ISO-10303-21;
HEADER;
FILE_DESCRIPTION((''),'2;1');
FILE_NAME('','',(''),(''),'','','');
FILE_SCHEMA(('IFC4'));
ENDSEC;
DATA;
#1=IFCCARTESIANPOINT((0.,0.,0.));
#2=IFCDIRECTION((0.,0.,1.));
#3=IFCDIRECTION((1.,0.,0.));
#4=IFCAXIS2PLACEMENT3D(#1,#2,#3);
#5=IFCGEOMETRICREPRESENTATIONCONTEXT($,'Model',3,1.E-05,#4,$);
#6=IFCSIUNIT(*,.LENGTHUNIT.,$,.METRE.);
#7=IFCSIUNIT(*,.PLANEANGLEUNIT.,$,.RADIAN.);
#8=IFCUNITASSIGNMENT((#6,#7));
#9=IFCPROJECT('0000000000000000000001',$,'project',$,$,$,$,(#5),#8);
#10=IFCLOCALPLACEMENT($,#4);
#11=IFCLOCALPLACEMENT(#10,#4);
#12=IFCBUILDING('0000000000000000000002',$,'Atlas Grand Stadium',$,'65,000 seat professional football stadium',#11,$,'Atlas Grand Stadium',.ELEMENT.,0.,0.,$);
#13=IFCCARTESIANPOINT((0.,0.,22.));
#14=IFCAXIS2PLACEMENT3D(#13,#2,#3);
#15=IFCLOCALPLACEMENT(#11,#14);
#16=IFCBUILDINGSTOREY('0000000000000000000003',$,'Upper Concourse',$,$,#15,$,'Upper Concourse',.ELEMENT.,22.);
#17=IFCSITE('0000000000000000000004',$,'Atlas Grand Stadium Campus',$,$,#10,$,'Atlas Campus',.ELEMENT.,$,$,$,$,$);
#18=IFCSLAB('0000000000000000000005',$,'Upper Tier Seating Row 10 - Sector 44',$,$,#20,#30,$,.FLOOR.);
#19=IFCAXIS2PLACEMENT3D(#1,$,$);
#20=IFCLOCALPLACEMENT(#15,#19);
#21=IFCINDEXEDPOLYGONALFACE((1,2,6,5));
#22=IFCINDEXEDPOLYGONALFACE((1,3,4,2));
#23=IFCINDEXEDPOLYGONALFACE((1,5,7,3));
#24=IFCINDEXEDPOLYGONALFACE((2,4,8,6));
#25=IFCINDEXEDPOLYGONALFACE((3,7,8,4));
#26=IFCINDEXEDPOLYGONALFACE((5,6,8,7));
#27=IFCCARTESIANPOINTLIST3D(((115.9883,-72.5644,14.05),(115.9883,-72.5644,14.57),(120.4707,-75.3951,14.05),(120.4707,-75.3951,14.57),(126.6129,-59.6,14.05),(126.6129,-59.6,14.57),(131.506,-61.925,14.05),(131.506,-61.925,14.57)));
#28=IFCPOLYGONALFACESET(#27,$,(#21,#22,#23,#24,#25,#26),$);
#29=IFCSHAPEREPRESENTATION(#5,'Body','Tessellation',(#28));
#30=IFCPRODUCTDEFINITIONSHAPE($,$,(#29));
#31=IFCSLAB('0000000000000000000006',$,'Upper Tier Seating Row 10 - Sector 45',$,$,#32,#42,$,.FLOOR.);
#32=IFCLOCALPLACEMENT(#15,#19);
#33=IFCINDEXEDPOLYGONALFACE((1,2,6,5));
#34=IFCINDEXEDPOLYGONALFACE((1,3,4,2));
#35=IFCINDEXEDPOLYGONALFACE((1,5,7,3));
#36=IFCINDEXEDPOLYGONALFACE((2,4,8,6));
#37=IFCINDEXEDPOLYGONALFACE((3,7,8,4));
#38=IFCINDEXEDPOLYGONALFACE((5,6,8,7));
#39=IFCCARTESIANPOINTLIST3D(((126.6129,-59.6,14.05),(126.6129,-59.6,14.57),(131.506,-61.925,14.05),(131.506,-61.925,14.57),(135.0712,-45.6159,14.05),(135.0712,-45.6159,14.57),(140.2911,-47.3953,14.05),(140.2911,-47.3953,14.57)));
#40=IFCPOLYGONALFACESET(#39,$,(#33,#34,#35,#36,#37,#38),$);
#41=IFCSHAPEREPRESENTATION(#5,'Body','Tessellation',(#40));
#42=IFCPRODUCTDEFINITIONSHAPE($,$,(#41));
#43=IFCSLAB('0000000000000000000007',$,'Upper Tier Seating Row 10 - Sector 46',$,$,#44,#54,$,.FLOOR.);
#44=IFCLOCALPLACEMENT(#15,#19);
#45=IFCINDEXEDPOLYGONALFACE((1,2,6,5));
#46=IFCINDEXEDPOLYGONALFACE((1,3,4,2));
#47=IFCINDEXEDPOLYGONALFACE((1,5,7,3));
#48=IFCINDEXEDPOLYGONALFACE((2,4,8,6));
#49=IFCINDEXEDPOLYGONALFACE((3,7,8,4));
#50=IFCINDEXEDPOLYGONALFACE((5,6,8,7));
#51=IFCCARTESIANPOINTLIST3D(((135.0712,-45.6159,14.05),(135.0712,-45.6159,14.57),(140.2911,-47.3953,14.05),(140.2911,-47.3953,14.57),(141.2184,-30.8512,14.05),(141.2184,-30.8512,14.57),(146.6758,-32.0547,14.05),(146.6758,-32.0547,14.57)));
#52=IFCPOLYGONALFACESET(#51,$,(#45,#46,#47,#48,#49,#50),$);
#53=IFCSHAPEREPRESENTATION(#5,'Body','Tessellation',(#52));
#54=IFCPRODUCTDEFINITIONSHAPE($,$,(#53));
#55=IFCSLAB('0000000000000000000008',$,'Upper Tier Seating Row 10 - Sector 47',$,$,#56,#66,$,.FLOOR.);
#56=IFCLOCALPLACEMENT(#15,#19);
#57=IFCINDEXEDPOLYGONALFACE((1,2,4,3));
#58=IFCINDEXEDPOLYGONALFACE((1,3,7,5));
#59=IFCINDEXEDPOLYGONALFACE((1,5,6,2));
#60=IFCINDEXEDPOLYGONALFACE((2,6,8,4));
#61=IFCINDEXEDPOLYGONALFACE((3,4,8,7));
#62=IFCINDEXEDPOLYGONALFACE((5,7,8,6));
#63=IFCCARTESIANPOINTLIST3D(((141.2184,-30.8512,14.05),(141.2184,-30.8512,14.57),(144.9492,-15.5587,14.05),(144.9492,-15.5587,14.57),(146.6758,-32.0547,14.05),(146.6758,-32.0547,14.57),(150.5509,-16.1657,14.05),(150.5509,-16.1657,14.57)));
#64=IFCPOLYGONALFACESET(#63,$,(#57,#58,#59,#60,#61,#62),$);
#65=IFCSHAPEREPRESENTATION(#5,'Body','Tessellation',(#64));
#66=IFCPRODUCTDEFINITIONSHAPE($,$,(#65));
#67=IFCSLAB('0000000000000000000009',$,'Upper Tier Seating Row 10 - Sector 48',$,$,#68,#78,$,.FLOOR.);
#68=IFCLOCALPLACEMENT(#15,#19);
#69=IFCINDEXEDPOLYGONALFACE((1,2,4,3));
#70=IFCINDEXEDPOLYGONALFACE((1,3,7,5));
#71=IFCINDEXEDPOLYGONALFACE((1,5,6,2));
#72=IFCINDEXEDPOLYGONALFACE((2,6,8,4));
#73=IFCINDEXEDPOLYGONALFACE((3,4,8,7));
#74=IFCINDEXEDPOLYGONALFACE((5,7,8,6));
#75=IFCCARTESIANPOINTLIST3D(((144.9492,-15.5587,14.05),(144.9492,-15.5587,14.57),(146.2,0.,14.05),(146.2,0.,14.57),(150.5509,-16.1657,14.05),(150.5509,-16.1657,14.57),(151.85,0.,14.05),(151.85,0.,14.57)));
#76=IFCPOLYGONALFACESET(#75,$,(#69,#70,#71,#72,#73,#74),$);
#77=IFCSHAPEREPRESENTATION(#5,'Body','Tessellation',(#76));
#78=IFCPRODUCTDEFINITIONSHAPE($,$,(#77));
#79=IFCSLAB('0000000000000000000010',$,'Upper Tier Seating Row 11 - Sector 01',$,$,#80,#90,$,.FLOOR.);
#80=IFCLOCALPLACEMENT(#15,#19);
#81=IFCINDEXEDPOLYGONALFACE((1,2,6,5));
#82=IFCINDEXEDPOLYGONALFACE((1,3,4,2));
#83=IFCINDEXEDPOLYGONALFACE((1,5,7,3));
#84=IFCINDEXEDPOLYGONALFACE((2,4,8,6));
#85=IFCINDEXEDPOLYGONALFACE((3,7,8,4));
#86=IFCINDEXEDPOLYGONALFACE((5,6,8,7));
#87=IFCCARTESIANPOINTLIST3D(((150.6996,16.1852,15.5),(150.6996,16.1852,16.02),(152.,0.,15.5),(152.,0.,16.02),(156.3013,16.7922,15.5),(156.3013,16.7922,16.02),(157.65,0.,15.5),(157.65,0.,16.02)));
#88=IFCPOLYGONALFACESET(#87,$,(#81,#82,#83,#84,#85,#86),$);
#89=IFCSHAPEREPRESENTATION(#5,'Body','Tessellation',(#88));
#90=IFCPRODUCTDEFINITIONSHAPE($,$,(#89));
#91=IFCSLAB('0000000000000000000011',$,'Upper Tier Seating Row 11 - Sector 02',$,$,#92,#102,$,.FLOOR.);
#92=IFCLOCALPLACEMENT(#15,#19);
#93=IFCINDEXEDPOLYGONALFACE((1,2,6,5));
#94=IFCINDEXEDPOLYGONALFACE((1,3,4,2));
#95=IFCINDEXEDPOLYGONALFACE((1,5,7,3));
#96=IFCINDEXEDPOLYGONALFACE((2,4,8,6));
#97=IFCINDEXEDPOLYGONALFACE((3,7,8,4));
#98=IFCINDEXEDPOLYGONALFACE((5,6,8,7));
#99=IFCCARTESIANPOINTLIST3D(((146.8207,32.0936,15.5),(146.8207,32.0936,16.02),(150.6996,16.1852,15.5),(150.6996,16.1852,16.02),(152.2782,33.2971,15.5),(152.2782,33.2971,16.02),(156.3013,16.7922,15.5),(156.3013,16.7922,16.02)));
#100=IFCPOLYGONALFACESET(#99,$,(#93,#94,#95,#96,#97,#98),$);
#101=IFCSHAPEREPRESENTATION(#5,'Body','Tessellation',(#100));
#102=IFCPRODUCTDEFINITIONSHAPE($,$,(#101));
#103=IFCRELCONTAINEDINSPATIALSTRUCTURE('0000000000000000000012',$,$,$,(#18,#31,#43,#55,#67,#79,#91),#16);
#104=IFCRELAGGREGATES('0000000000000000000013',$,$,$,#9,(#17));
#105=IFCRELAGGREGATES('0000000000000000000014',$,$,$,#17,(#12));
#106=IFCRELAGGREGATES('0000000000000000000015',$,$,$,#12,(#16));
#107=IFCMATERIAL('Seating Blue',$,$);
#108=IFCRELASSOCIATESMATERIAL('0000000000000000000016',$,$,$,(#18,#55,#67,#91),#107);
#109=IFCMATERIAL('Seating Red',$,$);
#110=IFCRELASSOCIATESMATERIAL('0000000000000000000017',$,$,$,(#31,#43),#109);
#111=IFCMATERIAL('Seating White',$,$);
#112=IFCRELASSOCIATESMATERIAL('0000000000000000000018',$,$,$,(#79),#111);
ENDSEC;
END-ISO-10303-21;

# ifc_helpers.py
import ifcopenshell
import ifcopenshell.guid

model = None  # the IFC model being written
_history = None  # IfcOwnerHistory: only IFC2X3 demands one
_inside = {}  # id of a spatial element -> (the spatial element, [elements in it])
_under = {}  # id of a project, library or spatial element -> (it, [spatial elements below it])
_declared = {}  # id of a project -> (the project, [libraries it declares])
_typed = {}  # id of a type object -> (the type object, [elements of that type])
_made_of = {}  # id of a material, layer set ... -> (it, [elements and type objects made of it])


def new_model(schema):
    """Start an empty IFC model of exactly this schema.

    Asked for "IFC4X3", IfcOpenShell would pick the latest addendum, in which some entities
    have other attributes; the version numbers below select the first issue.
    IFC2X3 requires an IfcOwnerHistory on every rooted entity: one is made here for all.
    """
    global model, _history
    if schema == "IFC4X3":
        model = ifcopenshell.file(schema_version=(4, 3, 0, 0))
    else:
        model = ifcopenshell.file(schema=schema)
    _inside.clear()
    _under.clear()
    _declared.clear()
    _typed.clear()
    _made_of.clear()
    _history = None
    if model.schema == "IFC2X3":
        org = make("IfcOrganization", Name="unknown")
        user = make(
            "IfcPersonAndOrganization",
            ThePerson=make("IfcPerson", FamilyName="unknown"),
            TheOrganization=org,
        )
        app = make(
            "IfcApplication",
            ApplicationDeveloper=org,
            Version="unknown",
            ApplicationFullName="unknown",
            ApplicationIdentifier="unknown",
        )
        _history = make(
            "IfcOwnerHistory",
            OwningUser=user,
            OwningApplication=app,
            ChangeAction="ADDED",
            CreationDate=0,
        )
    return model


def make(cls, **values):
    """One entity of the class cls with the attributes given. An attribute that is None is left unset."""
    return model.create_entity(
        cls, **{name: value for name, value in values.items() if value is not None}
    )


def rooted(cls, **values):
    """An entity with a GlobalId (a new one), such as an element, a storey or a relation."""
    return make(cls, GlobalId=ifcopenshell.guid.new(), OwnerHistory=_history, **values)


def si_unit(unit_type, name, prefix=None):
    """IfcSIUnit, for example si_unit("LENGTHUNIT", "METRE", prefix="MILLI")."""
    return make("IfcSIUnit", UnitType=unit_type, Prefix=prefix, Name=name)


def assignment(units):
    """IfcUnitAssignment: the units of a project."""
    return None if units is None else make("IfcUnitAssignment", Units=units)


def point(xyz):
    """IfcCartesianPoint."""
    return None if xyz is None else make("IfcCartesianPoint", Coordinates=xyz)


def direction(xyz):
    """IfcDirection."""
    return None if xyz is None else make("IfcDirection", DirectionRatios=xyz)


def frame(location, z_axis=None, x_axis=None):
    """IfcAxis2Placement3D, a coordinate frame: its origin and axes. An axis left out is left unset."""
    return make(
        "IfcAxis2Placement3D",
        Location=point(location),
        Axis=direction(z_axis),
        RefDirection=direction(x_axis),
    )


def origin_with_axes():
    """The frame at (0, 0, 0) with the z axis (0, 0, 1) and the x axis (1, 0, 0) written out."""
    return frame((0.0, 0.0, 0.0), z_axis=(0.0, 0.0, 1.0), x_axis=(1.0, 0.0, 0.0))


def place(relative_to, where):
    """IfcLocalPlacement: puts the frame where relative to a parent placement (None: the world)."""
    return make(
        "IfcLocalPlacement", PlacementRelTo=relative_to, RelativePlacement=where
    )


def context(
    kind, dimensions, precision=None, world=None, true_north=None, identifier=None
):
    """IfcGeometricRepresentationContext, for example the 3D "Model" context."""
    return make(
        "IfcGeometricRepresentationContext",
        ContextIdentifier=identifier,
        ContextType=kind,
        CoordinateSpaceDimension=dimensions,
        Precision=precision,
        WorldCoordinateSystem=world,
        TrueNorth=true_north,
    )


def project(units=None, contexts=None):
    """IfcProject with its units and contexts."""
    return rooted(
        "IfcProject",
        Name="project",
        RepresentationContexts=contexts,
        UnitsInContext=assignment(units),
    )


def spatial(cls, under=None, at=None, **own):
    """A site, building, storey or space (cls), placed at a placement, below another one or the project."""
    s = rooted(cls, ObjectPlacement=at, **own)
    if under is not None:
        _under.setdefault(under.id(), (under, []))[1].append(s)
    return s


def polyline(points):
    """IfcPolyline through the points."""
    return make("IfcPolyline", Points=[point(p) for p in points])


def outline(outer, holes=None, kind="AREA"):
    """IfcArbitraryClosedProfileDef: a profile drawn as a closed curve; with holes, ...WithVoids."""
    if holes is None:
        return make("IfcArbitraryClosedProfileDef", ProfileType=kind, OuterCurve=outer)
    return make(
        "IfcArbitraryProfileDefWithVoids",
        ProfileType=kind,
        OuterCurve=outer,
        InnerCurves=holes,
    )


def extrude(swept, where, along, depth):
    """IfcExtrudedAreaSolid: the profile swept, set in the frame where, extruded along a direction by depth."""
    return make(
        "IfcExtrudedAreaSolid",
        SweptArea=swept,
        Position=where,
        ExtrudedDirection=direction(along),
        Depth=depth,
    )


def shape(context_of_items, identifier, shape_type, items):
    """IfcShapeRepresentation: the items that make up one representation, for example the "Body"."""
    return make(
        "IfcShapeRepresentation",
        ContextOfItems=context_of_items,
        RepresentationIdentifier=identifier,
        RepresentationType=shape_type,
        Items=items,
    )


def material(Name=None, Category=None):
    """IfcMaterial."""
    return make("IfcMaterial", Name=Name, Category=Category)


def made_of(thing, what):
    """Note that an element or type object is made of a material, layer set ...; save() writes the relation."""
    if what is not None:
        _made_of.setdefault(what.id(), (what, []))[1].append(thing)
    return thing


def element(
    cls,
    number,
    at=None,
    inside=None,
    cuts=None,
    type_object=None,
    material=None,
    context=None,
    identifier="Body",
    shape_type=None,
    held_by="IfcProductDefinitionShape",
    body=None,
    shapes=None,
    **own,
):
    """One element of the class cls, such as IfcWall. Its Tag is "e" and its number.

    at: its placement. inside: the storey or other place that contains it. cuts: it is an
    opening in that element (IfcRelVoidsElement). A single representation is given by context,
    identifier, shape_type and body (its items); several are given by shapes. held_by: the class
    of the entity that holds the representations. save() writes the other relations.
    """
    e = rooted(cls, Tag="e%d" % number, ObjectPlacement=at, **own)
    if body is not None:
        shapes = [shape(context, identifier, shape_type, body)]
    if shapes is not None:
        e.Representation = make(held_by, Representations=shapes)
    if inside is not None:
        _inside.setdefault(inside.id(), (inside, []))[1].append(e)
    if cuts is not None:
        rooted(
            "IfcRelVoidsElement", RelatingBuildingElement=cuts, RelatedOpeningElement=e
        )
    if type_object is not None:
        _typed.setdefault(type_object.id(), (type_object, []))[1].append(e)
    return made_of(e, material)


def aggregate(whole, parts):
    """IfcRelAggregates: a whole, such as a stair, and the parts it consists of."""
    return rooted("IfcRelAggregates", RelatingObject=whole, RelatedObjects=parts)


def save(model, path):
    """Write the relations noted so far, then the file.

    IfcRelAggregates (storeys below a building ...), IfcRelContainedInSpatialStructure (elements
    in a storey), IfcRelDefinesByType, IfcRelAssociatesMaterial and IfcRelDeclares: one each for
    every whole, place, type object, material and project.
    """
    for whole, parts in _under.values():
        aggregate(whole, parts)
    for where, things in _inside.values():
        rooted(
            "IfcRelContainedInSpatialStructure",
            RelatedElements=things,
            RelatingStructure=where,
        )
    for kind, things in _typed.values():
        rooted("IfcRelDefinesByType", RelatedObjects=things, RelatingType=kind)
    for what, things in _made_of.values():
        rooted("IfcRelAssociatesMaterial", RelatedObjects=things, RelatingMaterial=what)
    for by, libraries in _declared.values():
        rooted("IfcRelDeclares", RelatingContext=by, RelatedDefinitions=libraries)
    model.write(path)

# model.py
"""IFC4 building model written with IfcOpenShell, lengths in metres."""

from ifc_helpers import new_model, si_unit, frame, origin_with_axes, place, context, project, spatial, polyline, outline, extrude, material, element, save


model = new_model("IFC4")

# Units and contexts
model_context = context("Model", 3, precision=1e-05, world=origin_with_axes())
ifc_project = project(units=[si_unit("LENGTHUNIT", "METRE"), si_unit("PLANEANGLEUNIT", "RADIAN")], contexts=[model_context])

# Site, building, storey
site_placement = place(None, origin_with_axes())
site = spatial("IfcSite", under=ifc_project, at=site_placement, Name="Atlas Grand Stadium Campus", LongName="Atlas Campus", CompositionType="ELEMENT")
building_placement = place(site_placement, origin_with_axes())
building = spatial("IfcBuilding", under=site, at=building_placement, Name="Atlas Grand Stadium", ObjectType="65,000 seat professional football stadium", LongName="Atlas Grand Stadium", CompositionType="ELEMENT", ElevationOfRefHeight=0.0, ElevationOfTerrain=0.0)
storey_placement = place(building_placement, frame((0.0, 0.0, 22.0), z_axis=(0.0, 0.0, 1.0), x_axis=(1.0, 0.0, 0.0)))
storey = spatial("IfcBuildingStorey", under=building, at=storey_placement, Name="Upper Concourse", LongName="Upper Concourse", CompositionType="ELEMENT", Elevation=22.0)

# Slabs
ifc_material_1 = material(Name="Seating Blue")
ifc_material_2 = material(Name="Seating Red")
ifc_material_3 = material(Name="Seating White")
slab_1_placement = place(storey_placement, frame((0.0, 0.0, 14.05), z_axis=(0.0, 0.0, 1.0), x_axis=(1.0, 0.0, 0.0)))
element("IfcSlab", 1, at=slab_1_placement, inside=storey, material=ifc_material_1, Name="Upper Tier Seating Row 10 - Sector 44", PredefinedType="FLOOR", context=model_context, shape_type="SweptSolid", body=[
    extrude(outline(polyline([(120.4707, -75.3951), (131.506, -61.925), (126.6129, -59.6), (115.9883, -72.5644), (120.4707, -75.3951)])), origin_with_axes(), (0.0, 0.0, 1.0), 0.52),
])
slab_2_placement = place(storey_placement, frame((0.0, 0.0, 14.05), z_axis=(0.0, 0.0, 1.0), x_axis=(1.0, 0.0, 0.0)))
element("IfcSlab", 2, at=slab_2_placement, inside=storey, material=ifc_material_2, Name="Upper Tier Seating Row 10 - Sector 45", PredefinedType="FLOOR", context=model_context, shape_type="SweptSolid", body=[
    extrude(outline(polyline([(131.506, -61.925), (140.2911, -47.3953), (135.0712, -45.6159), (126.6129, -59.6), (131.506, -61.925)])), origin_with_axes(), (0.0, 0.0, 1.0), 0.52),
])
slab_3_placement = place(storey_placement, frame((0.0, 0.0, 14.05), z_axis=(0.0, 0.0, 1.0), x_axis=(1.0, 0.0, 0.0)))
element("IfcSlab", 3, at=slab_3_placement, inside=storey, material=ifc_material_2, Name="Upper Tier Seating Row 10 - Sector 46", PredefinedType="FLOOR", context=model_context, shape_type="SweptSolid", body=[
    extrude(outline(polyline([(140.2911, -47.3953), (146.6758, -32.0547), (141.2184, -30.8512), (135.0712, -45.6159), (140.2911, -47.3953)])), origin_with_axes(), (0.0, 0.0, 1.0), 0.52),
])
slab_4_placement = place(storey_placement, frame((0.0, 0.0, 14.05), z_axis=(0.0, 0.0, 1.0), x_axis=(1.0, 0.0, 0.0)))
element("IfcSlab", 4, at=slab_4_placement, inside=storey, material=ifc_material_1, Name="Upper Tier Seating Row 10 - Sector 47", PredefinedType="FLOOR", context=model_context, shape_type="SweptSolid", body=[
    extrude(outline(polyline([(146.6758, -32.0547), (150.5509, -16.1657), (144.9492, -15.5587), (141.2184, -30.8512), (146.6758, -32.0547)])), origin_with_axes(), (0.0, 0.0, 1.0), 0.52),
])
slab_5_placement = place(storey_placement, frame((0.0, 0.0, 14.05), z_axis=(0.0, 0.0, 1.0), x_axis=(1.0, 0.0, 0.0)))
element("IfcSlab", 5, at=slab_5_placement, inside=storey, material=ifc_material_1, Name="Upper Tier Seating Row 10 - Sector 48", PredefinedType="FLOOR", context=model_context, shape_type="SweptSolid", body=[
    extrude(outline(polyline([(150.5509, -16.1657), (151.85, 0.0), (146.2, 0.0), (144.9492, -15.5587), (150.5509, -16.1657)])), origin_with_axes(), (0.0, 0.0, 1.0), 0.52),
])
slab_6_placement = place(storey_placement, frame((0.0, 0.0, 15.5), z_axis=(0.0, 0.0, 1.0), x_axis=(1.0, 0.0, 0.0)))
element("IfcSlab", 6, at=slab_6_placement, inside=storey, material=ifc_material_3, Name="Upper Tier Seating Row 11 - Sector 01", PredefinedType="FLOOR", context=model_context, shape_type="SweptSolid", body=[
    extrude(outline(polyline([(157.65, 0.0), (156.3013, 16.7922), (150.6996, 16.1852), (152.0, 0.0), (157.65, 0.0)])), origin_with_axes(), (0.0, 0.0, 1.0), 0.52),
])
slab_7_placement = place(storey_placement, frame((0.0, 0.0, 15.5), z_axis=(0.0, 0.0, 1.0), x_axis=(1.0, 0.0, 0.0)))
element("IfcSlab", 7, at=slab_7_placement, inside=storey, material=ifc_material_1, Name="Upper Tier Seating Row 11 - Sector 02", PredefinedType="FLOOR", context=model_context, shape_type="SweptSolid", body=[
    extrude(outline(polyline([(156.3013, 16.7922), (152.2782, 33.2971), (146.8207, 32.0936), (150.6996, 16.1852), (156.3013, 16.7922)])), origin_with_axes(), (0.0, 0.0, 1.0), 0.52),
])

save(model, "model.ifc")
